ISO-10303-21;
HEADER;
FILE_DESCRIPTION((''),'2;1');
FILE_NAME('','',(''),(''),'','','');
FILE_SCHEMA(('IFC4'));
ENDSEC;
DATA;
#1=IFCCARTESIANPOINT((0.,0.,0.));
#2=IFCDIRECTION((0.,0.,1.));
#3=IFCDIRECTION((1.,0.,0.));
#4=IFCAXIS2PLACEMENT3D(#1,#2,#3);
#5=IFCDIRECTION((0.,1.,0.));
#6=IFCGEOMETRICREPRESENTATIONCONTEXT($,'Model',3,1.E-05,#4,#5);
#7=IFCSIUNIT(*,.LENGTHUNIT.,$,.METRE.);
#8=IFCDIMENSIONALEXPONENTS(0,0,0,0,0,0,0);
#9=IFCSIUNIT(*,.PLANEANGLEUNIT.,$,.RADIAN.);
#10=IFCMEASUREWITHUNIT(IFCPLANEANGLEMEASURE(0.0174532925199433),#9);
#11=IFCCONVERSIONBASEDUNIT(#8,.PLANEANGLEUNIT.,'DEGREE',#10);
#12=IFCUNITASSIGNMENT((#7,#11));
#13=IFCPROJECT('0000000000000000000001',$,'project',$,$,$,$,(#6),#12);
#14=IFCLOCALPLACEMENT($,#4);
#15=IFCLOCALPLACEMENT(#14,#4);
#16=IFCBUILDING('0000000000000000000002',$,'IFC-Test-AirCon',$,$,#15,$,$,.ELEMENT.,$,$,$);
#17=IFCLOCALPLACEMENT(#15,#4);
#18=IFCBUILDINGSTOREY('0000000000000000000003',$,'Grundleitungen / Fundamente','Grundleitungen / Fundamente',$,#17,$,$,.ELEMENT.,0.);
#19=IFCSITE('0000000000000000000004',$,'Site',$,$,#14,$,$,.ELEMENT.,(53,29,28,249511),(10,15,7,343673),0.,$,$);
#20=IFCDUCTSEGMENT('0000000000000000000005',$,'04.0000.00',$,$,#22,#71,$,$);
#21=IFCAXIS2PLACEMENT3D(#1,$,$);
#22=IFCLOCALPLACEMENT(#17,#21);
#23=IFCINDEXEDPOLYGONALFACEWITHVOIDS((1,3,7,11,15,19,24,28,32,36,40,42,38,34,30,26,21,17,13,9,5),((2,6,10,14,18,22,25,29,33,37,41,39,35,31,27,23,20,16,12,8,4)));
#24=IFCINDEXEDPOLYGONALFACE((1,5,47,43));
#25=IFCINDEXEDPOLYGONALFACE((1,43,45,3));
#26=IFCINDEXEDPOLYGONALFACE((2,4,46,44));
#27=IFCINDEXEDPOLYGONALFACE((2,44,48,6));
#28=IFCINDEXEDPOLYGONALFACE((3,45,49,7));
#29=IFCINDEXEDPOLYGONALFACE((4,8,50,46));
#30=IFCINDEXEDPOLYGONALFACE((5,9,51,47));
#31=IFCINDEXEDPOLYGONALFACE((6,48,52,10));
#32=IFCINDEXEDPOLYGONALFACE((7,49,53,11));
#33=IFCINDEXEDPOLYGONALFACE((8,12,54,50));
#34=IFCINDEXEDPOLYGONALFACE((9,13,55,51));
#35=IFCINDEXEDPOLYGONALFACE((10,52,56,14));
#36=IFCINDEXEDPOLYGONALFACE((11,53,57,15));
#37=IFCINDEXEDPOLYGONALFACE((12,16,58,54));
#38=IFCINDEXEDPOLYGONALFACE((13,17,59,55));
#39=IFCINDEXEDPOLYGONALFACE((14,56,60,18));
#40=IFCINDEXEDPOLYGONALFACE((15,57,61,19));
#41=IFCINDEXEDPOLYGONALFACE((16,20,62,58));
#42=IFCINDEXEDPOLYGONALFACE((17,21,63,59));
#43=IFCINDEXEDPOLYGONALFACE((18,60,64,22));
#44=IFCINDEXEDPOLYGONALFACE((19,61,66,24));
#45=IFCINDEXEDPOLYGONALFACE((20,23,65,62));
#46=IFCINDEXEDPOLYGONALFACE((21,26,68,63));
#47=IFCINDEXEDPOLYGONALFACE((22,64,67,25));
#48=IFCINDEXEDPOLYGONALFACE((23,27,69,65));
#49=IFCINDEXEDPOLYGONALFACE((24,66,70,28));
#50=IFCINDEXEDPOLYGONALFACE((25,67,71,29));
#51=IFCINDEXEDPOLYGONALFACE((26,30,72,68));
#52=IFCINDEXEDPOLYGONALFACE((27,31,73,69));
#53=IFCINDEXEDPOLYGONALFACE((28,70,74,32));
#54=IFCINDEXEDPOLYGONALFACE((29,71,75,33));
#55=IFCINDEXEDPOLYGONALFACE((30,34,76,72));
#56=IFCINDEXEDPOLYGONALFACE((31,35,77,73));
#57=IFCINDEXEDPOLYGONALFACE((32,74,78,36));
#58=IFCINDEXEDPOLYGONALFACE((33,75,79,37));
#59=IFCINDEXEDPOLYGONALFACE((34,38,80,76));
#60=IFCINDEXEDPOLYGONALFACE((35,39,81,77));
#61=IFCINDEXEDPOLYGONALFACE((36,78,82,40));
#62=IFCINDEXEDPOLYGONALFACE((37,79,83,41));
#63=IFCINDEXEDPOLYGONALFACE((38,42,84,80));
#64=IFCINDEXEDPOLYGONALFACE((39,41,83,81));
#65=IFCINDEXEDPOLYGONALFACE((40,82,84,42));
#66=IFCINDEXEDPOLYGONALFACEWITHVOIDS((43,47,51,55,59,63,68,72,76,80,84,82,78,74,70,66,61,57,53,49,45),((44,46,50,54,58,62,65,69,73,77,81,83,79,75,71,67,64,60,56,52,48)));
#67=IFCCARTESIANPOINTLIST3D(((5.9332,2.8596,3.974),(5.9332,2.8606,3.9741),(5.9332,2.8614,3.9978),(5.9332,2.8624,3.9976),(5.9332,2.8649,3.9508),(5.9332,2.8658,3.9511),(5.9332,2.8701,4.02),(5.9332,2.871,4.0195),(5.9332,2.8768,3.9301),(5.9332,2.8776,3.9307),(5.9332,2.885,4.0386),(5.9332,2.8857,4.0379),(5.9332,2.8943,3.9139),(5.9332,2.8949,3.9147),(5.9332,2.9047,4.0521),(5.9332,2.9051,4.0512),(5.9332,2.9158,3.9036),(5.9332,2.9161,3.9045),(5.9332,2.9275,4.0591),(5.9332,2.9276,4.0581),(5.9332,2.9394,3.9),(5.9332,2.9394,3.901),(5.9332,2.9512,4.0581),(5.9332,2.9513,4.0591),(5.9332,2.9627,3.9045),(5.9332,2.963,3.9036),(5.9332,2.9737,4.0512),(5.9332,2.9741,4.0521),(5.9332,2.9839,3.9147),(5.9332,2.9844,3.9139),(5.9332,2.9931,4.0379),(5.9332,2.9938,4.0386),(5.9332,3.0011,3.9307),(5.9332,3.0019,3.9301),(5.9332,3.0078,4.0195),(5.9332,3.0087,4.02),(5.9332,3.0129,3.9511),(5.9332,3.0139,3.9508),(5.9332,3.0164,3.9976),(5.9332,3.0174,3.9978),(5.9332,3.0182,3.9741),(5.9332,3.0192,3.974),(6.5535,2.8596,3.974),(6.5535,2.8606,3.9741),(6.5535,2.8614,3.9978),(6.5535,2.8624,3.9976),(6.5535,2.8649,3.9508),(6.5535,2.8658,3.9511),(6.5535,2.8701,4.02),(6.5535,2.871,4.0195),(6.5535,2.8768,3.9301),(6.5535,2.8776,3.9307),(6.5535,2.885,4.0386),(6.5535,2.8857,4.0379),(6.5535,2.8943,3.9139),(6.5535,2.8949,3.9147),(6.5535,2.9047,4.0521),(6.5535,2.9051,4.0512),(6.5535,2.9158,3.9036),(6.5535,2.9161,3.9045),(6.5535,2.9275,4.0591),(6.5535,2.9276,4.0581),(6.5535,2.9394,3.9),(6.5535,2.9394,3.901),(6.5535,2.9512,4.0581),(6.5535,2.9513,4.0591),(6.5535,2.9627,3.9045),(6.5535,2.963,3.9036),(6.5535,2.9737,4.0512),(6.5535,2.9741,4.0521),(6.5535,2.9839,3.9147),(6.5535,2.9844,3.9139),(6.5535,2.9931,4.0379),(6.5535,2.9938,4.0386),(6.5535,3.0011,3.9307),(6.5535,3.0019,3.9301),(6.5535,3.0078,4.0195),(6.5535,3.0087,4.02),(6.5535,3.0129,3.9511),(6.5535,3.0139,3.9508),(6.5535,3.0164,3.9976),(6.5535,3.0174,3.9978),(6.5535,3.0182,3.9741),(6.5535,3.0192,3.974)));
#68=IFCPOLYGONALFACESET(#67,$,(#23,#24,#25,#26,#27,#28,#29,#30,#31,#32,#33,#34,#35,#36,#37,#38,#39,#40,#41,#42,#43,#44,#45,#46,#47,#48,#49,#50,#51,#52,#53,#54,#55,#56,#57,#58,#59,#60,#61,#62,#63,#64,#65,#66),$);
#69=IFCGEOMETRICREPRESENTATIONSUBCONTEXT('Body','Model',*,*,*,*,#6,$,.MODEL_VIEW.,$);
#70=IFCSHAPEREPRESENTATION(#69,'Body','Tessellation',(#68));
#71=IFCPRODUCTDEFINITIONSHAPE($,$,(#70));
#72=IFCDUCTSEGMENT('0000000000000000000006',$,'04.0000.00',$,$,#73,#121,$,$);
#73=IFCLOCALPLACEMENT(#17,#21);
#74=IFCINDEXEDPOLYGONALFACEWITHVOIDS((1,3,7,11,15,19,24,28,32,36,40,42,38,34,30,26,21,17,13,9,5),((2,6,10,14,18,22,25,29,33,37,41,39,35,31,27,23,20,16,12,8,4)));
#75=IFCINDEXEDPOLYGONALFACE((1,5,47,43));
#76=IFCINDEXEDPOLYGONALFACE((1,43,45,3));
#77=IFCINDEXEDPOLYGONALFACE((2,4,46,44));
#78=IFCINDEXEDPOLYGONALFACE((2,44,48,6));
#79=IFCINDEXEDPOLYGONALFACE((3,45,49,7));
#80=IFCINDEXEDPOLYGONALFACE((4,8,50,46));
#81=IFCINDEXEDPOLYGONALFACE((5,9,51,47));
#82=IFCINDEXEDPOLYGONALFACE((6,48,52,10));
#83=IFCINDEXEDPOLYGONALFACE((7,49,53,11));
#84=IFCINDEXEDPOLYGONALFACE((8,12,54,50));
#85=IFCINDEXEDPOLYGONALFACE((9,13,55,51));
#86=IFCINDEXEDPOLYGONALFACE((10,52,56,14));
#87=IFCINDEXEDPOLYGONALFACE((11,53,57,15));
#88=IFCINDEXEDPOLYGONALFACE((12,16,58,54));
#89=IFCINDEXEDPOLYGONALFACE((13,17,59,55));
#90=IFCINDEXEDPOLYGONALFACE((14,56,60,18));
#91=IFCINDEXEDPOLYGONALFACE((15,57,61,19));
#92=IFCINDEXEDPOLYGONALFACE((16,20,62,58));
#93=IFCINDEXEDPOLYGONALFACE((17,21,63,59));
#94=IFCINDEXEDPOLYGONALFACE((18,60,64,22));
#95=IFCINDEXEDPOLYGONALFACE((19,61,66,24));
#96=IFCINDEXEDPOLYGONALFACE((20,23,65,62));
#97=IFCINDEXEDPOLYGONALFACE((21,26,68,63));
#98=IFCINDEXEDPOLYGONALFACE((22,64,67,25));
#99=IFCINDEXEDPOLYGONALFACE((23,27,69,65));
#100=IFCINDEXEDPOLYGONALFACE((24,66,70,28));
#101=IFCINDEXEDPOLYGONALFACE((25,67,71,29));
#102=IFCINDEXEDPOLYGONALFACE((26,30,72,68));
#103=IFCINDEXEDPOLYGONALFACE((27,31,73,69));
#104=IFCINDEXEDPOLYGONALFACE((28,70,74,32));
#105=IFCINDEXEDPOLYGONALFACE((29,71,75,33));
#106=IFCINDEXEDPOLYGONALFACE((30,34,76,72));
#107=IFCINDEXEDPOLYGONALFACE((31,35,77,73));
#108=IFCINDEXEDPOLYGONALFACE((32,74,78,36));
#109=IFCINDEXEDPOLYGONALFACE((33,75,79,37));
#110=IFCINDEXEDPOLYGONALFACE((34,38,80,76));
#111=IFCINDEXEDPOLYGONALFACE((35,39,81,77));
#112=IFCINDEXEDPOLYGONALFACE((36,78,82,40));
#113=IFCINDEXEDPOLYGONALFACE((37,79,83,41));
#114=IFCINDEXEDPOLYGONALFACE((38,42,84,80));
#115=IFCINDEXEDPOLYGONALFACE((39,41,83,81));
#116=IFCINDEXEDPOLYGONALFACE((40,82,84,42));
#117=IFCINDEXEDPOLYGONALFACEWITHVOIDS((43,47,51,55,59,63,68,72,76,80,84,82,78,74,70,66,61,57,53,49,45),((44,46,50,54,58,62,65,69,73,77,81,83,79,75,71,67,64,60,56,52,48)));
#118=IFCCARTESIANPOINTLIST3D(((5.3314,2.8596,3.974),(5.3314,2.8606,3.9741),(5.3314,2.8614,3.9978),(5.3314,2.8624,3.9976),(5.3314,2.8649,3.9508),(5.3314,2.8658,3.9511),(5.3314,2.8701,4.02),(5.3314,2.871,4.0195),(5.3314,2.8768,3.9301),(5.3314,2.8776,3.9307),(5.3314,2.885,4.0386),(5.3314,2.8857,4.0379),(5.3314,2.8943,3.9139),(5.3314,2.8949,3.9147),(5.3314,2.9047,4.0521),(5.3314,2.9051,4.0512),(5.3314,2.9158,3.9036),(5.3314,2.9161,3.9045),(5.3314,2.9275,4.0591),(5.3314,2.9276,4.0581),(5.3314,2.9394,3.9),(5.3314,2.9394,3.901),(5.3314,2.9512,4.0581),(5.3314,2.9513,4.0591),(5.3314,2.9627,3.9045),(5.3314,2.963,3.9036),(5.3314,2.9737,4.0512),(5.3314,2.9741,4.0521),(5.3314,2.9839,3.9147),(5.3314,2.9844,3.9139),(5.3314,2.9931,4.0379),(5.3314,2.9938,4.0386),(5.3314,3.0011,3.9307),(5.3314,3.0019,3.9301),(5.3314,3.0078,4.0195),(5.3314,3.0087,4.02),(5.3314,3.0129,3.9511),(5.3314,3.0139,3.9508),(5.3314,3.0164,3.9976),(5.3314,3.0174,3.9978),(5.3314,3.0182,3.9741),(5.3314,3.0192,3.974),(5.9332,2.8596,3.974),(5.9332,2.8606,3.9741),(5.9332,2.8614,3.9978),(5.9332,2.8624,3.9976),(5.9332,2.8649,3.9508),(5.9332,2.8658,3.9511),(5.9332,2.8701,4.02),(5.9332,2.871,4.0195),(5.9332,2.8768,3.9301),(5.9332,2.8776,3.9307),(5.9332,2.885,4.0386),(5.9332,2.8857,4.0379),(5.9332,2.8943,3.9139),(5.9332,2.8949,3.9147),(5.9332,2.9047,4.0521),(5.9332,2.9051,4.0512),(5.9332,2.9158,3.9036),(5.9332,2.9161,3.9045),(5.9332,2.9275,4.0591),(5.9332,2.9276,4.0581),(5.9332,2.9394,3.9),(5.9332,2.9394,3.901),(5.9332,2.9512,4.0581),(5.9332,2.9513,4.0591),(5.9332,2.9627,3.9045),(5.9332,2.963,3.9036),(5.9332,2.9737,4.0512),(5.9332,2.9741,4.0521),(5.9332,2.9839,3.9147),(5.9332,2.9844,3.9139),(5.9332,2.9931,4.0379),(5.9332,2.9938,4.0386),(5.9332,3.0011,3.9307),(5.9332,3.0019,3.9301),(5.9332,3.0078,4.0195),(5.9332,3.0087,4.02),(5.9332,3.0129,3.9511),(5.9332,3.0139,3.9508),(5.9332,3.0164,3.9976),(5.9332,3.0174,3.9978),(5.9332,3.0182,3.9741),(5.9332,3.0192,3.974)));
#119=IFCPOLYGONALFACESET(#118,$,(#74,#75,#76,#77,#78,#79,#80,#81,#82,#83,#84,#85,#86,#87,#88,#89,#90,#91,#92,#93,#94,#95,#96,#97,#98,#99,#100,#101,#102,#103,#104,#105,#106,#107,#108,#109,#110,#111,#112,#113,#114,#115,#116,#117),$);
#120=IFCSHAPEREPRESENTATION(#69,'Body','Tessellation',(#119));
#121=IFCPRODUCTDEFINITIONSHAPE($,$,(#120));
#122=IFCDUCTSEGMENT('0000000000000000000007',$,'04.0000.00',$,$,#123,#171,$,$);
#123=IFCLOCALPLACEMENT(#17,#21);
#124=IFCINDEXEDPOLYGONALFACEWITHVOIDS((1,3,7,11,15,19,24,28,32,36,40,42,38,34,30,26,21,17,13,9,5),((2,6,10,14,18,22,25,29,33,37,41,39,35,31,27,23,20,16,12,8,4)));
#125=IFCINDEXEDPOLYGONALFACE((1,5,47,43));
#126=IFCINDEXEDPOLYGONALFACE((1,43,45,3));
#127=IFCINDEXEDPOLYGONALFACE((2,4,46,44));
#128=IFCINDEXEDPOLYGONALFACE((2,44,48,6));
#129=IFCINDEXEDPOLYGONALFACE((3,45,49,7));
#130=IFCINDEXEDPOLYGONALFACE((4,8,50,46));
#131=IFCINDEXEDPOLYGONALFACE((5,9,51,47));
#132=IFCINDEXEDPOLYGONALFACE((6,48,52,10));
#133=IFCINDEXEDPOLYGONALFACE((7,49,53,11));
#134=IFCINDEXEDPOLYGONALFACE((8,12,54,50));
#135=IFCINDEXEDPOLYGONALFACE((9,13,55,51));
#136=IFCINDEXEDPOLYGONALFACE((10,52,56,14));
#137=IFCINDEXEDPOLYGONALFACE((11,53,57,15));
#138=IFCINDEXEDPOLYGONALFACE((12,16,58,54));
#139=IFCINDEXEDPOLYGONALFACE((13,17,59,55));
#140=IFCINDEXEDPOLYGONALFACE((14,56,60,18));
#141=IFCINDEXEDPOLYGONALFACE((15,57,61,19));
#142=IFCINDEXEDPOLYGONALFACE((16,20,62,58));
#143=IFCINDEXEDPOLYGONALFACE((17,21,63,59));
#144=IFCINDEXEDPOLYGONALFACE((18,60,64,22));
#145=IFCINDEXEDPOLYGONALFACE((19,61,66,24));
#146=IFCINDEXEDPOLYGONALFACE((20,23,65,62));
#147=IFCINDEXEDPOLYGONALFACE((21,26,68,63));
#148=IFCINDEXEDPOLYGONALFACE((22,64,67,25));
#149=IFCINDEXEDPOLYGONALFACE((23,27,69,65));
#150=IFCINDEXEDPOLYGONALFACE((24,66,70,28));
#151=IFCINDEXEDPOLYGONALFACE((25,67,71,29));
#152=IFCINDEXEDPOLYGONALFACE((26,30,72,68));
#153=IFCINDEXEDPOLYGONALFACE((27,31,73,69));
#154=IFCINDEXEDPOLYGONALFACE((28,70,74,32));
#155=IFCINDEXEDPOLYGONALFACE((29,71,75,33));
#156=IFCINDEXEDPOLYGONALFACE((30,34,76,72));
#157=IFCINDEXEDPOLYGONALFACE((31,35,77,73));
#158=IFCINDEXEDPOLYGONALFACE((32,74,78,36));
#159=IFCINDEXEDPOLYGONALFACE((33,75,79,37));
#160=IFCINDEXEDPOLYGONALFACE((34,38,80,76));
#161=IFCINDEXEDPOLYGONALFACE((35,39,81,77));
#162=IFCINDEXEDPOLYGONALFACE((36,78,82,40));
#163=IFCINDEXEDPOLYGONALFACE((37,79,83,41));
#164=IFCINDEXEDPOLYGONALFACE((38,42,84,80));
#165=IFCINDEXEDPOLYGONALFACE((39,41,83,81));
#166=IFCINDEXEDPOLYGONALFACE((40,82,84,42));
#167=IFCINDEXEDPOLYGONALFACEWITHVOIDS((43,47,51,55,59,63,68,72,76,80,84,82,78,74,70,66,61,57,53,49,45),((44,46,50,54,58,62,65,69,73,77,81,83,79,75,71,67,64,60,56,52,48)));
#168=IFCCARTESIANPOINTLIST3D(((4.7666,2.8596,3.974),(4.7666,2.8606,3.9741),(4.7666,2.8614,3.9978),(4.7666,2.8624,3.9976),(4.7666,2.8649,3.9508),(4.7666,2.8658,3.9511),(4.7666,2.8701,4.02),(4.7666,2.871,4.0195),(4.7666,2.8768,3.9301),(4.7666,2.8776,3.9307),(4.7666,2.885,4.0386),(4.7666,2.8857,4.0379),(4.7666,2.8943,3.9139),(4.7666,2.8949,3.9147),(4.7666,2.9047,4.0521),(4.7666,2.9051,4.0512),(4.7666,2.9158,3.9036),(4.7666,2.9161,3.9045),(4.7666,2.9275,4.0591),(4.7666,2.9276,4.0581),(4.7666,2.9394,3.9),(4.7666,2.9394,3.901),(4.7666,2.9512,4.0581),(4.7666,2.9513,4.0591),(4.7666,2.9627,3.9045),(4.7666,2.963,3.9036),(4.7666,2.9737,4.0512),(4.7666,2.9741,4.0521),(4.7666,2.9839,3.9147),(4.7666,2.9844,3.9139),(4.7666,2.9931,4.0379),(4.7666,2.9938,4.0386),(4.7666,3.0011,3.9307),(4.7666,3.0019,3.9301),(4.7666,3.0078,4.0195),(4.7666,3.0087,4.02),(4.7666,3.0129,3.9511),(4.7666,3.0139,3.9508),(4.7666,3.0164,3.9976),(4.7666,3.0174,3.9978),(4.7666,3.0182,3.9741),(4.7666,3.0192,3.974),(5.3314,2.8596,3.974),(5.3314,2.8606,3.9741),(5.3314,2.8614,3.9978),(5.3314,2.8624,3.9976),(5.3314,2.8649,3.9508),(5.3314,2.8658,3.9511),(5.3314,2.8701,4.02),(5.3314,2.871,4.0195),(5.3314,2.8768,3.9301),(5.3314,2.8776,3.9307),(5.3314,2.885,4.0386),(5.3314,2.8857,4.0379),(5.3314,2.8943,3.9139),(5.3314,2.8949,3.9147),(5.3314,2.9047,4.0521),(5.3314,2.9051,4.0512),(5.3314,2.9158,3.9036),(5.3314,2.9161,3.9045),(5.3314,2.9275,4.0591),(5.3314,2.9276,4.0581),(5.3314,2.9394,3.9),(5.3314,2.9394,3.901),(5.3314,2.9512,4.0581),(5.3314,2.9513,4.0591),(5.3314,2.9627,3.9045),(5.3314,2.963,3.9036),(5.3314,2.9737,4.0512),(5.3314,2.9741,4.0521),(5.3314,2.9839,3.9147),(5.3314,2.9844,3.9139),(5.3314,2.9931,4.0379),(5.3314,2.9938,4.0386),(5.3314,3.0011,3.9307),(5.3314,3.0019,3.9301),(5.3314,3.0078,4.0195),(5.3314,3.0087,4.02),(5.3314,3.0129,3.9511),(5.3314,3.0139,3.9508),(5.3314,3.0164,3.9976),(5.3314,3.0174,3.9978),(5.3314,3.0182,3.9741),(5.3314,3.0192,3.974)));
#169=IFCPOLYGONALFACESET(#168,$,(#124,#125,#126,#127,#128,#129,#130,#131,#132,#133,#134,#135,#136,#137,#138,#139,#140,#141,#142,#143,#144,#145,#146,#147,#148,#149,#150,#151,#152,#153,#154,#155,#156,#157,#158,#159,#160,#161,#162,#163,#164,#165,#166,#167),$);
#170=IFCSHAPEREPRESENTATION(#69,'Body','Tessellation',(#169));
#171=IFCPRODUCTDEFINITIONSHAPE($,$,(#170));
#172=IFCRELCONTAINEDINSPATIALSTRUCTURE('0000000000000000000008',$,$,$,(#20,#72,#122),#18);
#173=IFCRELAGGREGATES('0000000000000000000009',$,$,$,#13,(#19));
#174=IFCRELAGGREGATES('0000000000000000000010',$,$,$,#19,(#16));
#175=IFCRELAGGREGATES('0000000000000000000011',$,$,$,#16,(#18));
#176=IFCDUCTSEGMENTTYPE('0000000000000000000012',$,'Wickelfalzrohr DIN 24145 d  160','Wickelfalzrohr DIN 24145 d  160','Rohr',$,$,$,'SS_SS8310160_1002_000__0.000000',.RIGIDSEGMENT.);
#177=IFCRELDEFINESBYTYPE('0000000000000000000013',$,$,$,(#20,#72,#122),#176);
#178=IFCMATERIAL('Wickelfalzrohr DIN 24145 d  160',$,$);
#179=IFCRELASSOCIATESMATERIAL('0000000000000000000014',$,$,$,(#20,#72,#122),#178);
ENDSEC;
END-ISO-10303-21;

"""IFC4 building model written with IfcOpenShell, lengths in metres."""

from ifc_helpers import new_model, entity, si_unit, converted_unit, direction, frame, origin_with_axes, origin_2d_with_axis, place, context, subcontext, project, spatial, hollow_circle, extrude, material, type_object, element, save


model = new_model("IFC4")

# Units and contexts
model_context = context("Model", 3, precision=1e-05, world=origin_with_axes(), true_north=direction((0.0, 1.0, 0.0)))
body_context = subcontext(model_context, "Body", "Model", "MODEL_VIEW")
ifc_project = project(units=[si_unit("LENGTHUNIT", "METRE"), converted_unit("PLANEANGLEUNIT", "DEGREE", entity("IfcPlaneAngleMeasure", 0.0174532925199433), si_unit("PLANEANGLEUNIT", "RADIAN"), dimensions=[0, 0, 0, 0, 0, 0, 0])], contexts=[model_context])

# Site, building, storey
site_placement = place(None, origin_with_axes())
site = spatial("IfcSite", under=ifc_project, at=site_placement, Name="Site", CompositionType="ELEMENT", RefLatitude=(53, 29, 28, 249511), RefLongitude=(10, 15, 7, 343673), RefElevation=0.0)
building_placement = place(site_placement, origin_with_axes())
building = spatial("IfcBuilding", under=site, at=building_placement, Name="IFC-Test-AirCon", CompositionType="ELEMENT")
storey_placement = place(building_placement, origin_with_axes())
storey = spatial("IfcBuildingStorey", under=building, at=storey_placement, Name="Grundleitungen / Fundamente", Description="Grundleitungen / Fundamente", CompositionType="ELEMENT", Elevation=0.0)

# Duct segments
ifc_material_1 = material(Name="Wickelfalzrohr DIN 24145 d  160")
duct_segment_type_1 = type_object("IfcDuctSegmentType", Name="Wickelfalzrohr DIN 24145 d  160", Description="Wickelfalzrohr DIN 24145 d  160", ApplicableOccurrence="Rohr", ElementType="SS_SS8310160_1002_000__0.000000", PredefinedType="RIGIDSEGMENT")
duct_segment_1_placement = place(storey_placement, frame((6.5535, 2.9394, 3.98), z_axis=(0.0, 0.0, 1.0), x_axis=(-1.0, 0.0, 0.0)))
element("IfcDuctSegment", 1, at=duct_segment_1_placement, inside=storey, type_object=duct_segment_type_1, material=ifc_material_1, Name="04.0000.00", context=body_context, shape_type="SweptSolid", body=[
    extrude(hollow_circle(Radius=0.08, WallThickness=0.001, at=origin_2d_with_axis()), frame((0.0, 0.0, 0.0), z_axis=(1.0, 0.0, 0.0), x_axis=(0.0, 0.0, -1.0)), (0.0, 0.0, 1.0), 0.6203),
])
duct_segment_2_placement = place(storey_placement, frame((5.9332, 2.9394, 3.98), z_axis=(0.0, 0.0, 1.0), x_axis=(-1.0, 0.0, 0.0)))
element("IfcDuctSegment", 2, at=duct_segment_2_placement, inside=storey, type_object=duct_segment_type_1, material=ifc_material_1, Name="04.0000.00", context=body_context, shape_type="SweptSolid", body=[
    extrude(hollow_circle(Radius=0.08, WallThickness=0.001, at=origin_2d_with_axis()), frame((0.0, 0.0, 0.0), z_axis=(1.0, 0.0, 0.0), x_axis=(0.0, 0.0, -1.0)), (0.0, 0.0, 1.0), 0.6018),
])
duct_segment_3_placement = place(storey_placement, frame((5.3314, 2.9394, 3.98), z_axis=(0.0, 0.0, 1.0), x_axis=(-1.0, 0.0, 0.0)))
element("IfcDuctSegment", 3, at=duct_segment_3_placement, inside=storey, type_object=duct_segment_type_1, material=ifc_material_1, Name="04.0000.00", context=body_context, shape_type="SweptSolid", body=[
    extrude(hollow_circle(Radius=0.08, WallThickness=0.001, at=origin_2d_with_axis()), frame((0.0, 0.0, 0.0), z_axis=(1.0, 0.0, 0.0), x_axis=(0.0, 0.0, -1.0)), (0.0, 0.0, 1.0), 0.5648),
])

save(model, "model.ifc")
